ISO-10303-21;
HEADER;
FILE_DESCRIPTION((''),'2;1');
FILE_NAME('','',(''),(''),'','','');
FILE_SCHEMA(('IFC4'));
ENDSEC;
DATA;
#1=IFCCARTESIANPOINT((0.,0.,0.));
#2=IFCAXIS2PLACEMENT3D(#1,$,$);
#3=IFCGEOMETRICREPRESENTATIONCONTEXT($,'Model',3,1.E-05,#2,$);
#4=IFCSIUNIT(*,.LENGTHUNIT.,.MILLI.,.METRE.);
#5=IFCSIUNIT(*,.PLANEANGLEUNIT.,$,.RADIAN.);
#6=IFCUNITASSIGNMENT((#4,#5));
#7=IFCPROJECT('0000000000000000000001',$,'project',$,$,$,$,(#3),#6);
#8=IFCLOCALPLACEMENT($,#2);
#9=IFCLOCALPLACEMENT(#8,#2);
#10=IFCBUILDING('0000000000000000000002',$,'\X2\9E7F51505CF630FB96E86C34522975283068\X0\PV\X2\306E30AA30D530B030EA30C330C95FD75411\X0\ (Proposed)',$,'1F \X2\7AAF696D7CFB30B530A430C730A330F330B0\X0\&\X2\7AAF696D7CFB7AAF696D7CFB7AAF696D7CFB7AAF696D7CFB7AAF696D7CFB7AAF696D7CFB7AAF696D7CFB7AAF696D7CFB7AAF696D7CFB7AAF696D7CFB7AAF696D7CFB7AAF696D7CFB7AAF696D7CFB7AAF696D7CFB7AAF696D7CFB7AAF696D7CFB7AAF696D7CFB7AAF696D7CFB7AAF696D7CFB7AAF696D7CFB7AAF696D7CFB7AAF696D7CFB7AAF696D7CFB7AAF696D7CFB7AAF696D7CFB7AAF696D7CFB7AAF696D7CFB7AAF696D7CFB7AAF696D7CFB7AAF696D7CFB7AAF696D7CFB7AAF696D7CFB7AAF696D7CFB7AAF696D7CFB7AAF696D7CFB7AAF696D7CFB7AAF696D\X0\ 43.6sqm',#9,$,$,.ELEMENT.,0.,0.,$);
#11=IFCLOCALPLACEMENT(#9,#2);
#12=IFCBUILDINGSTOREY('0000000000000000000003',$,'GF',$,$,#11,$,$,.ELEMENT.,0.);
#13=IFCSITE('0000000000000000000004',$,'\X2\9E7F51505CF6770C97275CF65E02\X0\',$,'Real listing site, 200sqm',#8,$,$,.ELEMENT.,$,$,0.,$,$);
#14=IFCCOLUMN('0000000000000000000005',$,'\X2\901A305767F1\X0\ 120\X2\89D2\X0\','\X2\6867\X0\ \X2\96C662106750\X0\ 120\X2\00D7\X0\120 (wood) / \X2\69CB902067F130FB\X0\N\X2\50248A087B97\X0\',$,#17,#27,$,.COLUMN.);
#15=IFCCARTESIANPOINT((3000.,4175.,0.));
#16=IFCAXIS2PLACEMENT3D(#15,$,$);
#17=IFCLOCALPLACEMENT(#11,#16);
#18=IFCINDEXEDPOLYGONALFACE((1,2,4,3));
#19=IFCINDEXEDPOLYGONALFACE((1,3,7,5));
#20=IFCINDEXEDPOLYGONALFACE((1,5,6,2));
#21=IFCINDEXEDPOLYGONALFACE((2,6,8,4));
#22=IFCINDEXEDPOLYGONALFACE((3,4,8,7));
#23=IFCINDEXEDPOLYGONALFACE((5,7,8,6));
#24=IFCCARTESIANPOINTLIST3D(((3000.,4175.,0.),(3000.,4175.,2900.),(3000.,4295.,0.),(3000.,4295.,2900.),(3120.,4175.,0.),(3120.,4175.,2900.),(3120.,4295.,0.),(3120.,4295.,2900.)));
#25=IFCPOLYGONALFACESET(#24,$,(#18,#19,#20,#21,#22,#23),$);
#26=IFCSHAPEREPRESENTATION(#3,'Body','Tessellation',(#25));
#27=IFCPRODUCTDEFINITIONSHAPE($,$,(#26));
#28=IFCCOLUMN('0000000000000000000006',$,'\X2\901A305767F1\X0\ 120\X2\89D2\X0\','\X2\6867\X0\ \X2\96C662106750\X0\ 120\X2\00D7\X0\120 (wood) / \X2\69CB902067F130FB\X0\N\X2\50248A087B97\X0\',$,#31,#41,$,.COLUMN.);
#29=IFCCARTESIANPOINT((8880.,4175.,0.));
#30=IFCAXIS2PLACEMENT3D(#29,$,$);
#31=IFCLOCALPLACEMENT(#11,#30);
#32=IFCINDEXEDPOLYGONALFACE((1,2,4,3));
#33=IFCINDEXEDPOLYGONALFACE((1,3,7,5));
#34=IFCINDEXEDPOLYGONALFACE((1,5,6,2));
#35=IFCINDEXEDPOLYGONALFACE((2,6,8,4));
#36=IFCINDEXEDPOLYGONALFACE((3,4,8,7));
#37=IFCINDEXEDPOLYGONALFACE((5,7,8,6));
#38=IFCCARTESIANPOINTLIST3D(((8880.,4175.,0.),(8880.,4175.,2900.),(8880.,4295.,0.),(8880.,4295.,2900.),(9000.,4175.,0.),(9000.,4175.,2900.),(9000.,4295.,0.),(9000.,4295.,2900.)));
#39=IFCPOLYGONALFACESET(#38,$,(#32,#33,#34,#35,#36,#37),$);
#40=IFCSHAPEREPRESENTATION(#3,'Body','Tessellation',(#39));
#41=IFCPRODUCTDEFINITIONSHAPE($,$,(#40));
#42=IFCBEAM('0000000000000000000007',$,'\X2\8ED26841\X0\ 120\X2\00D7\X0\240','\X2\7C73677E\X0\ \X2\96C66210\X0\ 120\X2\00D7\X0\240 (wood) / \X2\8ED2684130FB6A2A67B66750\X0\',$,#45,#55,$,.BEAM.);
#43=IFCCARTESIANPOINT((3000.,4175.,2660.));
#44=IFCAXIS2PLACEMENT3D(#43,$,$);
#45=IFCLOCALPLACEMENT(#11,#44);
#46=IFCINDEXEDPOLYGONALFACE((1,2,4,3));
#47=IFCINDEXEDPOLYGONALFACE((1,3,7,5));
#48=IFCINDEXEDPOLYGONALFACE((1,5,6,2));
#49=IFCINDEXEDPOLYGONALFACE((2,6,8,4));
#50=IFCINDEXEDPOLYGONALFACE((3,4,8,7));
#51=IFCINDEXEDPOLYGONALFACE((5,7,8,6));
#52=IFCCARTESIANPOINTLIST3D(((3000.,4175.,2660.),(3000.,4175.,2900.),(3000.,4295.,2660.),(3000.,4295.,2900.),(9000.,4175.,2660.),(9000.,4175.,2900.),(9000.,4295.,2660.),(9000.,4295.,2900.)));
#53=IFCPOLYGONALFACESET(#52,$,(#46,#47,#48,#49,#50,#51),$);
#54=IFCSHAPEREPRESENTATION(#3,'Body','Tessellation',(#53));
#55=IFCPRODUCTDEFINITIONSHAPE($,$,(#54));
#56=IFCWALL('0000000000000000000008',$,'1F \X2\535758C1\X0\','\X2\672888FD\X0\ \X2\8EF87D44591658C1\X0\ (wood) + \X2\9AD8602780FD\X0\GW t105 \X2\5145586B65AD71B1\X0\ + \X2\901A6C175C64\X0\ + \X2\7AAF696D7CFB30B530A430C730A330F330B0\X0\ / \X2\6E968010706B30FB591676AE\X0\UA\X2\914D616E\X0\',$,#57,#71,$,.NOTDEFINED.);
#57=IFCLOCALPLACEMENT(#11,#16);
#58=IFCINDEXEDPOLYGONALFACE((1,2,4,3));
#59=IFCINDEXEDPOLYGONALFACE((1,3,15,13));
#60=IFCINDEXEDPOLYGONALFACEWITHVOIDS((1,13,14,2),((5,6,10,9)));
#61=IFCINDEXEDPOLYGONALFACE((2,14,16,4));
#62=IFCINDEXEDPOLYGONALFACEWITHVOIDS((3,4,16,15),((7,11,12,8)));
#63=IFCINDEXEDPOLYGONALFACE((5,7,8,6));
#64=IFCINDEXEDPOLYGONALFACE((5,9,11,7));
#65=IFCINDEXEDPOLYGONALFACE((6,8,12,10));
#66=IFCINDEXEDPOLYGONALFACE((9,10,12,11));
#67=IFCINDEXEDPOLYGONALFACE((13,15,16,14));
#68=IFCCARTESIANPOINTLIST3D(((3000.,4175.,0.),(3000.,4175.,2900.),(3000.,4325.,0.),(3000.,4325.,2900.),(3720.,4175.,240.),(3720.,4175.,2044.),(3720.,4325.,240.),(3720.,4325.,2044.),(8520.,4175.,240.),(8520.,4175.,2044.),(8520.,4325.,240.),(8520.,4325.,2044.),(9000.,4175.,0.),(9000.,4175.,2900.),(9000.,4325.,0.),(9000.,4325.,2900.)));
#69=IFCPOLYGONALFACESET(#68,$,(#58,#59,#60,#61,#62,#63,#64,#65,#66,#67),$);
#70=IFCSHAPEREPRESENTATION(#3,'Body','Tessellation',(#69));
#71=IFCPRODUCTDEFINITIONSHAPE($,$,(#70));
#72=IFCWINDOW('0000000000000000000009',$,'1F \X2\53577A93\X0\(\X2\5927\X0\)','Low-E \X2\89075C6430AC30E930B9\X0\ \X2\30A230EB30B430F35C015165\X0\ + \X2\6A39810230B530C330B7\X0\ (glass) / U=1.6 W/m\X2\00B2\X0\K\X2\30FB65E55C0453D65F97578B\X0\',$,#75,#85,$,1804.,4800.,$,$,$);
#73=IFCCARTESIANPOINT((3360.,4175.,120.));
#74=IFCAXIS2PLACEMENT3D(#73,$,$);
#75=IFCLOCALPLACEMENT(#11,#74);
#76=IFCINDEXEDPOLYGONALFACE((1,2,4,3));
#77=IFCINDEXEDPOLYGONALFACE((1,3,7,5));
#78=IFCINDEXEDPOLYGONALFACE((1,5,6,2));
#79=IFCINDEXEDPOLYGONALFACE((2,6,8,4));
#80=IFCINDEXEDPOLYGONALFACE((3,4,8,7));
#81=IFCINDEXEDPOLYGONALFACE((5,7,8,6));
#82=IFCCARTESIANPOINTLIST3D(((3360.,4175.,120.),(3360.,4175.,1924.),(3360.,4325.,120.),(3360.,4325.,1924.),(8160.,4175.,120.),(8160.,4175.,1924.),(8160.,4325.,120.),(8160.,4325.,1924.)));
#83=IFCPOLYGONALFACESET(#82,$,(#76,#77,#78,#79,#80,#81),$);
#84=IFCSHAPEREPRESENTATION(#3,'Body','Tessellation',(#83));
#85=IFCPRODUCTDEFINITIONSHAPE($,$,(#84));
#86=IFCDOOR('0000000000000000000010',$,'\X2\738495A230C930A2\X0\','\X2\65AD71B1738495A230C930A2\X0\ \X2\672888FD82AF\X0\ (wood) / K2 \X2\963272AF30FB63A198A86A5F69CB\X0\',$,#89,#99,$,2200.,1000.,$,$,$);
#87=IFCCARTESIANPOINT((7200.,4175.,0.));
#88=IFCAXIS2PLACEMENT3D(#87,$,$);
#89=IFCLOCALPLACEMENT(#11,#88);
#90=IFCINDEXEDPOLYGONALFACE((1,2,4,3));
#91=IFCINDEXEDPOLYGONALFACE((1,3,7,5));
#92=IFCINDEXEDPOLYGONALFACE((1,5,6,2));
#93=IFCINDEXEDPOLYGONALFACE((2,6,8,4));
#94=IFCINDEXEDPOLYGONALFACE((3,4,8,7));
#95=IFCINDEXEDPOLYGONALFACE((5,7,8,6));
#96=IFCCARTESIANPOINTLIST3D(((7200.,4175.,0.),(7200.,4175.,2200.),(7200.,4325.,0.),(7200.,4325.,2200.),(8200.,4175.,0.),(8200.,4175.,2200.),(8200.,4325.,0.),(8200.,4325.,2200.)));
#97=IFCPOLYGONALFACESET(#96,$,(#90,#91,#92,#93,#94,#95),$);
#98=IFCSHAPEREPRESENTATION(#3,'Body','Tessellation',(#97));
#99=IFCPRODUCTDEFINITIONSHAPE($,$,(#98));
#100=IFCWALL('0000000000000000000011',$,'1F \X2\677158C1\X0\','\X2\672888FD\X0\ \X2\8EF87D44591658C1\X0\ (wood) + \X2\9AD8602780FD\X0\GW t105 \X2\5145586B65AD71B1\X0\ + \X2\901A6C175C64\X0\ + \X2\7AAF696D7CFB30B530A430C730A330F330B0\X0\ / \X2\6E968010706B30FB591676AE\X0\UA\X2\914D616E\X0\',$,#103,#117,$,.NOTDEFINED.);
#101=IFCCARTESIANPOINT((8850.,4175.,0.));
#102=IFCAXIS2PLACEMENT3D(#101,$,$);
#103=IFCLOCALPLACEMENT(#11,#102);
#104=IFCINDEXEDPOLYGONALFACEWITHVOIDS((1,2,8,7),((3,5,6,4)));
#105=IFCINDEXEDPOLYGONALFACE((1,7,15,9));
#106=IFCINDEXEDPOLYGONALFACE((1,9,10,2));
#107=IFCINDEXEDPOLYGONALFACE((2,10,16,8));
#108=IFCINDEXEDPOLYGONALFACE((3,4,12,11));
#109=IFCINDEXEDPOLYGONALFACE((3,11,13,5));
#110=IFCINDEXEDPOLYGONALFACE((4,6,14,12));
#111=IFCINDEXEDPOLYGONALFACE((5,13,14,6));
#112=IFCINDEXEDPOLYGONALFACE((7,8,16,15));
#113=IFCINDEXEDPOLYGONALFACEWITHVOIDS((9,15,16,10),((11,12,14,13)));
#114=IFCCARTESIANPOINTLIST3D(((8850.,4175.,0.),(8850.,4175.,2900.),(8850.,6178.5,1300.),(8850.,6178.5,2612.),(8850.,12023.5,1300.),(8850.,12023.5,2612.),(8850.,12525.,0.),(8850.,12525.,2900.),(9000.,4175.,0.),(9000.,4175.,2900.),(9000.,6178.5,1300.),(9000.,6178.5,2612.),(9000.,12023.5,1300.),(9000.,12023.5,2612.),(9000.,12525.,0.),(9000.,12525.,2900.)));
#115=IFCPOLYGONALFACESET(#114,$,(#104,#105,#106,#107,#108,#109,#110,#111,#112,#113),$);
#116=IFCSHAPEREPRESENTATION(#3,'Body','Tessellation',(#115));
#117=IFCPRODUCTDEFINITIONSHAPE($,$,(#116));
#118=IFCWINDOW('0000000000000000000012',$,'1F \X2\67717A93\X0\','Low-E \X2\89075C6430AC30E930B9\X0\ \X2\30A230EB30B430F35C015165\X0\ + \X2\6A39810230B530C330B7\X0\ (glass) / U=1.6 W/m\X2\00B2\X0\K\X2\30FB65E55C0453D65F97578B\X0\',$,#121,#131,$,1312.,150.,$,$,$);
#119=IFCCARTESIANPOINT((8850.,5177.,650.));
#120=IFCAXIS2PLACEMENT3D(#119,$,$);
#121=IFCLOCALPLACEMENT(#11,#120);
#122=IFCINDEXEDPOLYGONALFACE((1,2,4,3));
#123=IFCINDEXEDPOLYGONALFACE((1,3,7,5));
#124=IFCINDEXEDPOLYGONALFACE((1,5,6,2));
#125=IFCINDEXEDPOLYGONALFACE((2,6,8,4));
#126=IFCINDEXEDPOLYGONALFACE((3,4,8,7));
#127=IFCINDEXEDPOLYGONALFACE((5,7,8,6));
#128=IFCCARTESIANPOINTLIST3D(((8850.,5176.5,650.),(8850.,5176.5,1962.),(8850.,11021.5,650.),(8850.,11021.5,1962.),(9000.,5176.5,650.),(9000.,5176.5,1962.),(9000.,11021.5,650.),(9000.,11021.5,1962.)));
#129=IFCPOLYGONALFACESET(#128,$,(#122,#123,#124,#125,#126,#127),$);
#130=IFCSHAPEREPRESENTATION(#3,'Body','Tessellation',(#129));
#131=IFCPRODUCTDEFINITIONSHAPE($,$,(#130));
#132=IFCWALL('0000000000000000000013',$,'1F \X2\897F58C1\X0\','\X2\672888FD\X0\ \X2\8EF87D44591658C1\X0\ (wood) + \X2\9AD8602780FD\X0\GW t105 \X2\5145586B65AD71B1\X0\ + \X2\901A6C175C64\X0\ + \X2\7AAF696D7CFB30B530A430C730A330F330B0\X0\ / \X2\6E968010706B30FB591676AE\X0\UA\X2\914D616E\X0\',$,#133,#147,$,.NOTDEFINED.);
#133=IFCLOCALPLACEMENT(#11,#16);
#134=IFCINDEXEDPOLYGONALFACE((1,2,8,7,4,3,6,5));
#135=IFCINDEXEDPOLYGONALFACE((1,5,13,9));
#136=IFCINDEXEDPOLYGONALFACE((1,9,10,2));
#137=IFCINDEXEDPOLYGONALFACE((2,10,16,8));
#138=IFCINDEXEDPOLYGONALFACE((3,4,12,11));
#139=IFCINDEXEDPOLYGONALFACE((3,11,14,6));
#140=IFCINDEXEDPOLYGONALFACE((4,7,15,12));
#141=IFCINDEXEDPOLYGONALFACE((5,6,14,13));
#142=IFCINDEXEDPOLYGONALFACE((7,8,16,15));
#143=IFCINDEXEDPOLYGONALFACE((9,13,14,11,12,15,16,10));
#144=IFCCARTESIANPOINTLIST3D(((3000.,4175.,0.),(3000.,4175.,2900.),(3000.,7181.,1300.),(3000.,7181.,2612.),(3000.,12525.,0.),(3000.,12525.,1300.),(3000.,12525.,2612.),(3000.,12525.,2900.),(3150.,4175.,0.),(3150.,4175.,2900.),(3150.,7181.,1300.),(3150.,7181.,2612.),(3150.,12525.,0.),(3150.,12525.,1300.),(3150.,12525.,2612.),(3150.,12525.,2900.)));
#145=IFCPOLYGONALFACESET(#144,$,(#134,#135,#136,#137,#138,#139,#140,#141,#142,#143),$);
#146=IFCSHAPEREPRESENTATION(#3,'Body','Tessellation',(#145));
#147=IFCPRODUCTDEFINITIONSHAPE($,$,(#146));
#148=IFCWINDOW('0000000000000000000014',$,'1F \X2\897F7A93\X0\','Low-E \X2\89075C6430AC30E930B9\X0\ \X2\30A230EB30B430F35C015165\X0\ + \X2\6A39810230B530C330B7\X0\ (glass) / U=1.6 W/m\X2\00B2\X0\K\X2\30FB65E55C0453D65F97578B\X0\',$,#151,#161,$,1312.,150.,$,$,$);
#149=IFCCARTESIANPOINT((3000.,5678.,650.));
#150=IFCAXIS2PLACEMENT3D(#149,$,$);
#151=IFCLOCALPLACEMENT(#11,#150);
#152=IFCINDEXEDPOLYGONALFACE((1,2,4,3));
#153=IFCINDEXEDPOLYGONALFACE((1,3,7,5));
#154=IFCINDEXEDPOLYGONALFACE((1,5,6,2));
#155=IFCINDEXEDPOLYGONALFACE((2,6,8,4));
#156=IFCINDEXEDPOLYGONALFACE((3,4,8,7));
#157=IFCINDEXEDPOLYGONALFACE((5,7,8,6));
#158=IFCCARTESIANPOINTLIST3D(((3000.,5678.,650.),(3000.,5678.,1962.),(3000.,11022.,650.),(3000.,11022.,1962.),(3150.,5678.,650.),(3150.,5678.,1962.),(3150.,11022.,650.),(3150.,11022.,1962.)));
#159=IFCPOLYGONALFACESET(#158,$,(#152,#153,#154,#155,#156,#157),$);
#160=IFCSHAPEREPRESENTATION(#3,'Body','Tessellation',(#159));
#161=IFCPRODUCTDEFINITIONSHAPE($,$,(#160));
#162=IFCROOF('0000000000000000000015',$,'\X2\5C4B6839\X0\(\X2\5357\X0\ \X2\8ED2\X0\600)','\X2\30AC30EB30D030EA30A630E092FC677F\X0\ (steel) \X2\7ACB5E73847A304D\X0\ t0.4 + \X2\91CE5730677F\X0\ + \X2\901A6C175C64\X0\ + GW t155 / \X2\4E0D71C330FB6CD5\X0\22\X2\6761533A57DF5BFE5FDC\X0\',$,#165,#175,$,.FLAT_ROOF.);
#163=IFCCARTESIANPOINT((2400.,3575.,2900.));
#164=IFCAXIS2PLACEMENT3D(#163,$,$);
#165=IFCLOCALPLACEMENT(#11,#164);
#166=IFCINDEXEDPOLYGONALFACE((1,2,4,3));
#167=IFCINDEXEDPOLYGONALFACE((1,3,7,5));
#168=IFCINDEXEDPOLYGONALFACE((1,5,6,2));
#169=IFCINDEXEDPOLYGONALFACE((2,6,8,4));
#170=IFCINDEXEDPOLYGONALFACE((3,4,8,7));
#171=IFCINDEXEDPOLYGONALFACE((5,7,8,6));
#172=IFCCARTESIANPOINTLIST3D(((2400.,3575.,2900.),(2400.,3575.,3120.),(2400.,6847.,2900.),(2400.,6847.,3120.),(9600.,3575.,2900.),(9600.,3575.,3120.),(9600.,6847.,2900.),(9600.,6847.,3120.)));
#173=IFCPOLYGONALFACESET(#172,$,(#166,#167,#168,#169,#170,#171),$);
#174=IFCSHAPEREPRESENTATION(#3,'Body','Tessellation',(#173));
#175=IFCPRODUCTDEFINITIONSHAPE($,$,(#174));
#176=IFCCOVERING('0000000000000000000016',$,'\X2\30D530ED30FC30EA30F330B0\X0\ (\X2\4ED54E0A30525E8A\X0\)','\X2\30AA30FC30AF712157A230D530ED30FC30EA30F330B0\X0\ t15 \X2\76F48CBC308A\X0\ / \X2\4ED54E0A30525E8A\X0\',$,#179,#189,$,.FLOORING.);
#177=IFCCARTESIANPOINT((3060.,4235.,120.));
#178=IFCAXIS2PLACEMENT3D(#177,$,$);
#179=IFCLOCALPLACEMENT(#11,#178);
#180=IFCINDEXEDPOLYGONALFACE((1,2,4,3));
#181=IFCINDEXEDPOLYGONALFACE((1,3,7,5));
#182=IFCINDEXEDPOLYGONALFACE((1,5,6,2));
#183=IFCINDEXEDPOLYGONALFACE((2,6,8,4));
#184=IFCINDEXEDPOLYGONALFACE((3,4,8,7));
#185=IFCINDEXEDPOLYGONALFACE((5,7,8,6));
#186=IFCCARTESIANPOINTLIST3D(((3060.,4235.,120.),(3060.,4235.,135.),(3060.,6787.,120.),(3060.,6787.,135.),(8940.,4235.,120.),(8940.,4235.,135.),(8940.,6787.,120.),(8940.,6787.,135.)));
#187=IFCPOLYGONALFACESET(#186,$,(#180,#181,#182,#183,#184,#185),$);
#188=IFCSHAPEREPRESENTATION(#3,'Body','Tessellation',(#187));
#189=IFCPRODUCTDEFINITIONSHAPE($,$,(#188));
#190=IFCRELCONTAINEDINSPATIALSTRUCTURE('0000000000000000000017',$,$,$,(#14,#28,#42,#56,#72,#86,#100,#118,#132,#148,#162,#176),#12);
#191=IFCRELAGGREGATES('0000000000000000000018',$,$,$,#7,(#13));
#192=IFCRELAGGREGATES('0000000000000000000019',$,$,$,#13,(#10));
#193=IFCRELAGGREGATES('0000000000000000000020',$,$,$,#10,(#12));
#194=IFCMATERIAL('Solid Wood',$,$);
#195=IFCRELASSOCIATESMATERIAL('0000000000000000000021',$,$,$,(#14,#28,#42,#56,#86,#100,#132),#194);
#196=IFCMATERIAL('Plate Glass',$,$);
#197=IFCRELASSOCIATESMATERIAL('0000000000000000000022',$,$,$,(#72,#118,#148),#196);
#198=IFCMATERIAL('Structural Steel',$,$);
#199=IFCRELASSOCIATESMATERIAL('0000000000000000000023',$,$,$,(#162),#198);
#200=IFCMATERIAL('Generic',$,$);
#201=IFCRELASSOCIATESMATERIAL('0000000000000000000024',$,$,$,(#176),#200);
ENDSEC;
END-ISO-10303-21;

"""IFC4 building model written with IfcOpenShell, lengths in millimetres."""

from ifc_helpers import new_model, si_unit, frame, frame_2d, origin, place, context, project, spatial, rectangle, extrude, material, element, fill, save


model = new_model("IFC4")

# Units and contexts
model_context = context("Model", 3, precision=1e-05, world=origin())
ifc_project = project(units=[si_unit("LENGTHUNIT", "METRE", prefix="MILLI"), si_unit("PLANEANGLEUNIT", "RADIAN")], contexts=[model_context])

# Site, building, storey
site_placement = place(None, origin())
site = spatial("IfcSite", under=ifc_project, at=site_placement, Name="鹿児島県霧島市", ObjectType="Real listing site, 200sqm", CompositionType="ELEMENT", RefElevation=0.0)
building_placement = place(site_placement, origin())
building = spatial("IfcBuilding", under=site, at=building_placement, Name="鹿児島・雨水利用とPVのオフグリッド志向 (Proposed)", ObjectType="1F 窯業系サイディング&窯業系窯業系窯業系窯業系窯業系窯業系窯業系窯業系窯業系窯業系窯業系窯業系窯業系窯業系窯業系窯業系窯業系窯業系窯業系窯業系窯業系窯業系窯業系窯業系窯業系窯業系窯業系窯業系窯業系窯業系窯業系窯業系窯業系窯業系窯業系窯業系窯業 43.6sqm", CompositionType="ELEMENT", ElevationOfRefHeight=0.0, ElevationOfTerrain=0.0)
storey_placement = place(building_placement, origin())
storey = spatial("IfcBuildingStorey", under=building, at=storey_placement, Name="GF", CompositionType="ELEMENT", Elevation=0.0)

# Columns
ifc_material_1 = material(Name="Solid Wood")
column_1_placement = place(storey_placement, frame((3000.0, 4175.0, 0.0)))
element("IfcColumn", 1, at=column_1_placement, inside=storey, material=ifc_material_1, Name="通し柱 120角", Description="桧 集成材 120×120 (wood) / 構造柱・N値計算", PredefinedType="COLUMN", context=model_context, shape_type="SweptSolid", body=[
    extrude(rectangle(XDim=120.0, YDim=120.0, at=frame_2d((60.0, 60.0))), frame((3000.0, 4175.0, 0.0)), (0.0, 0.0, 1.0), 2900.0),
])
column_2_placement = place(storey_placement, frame((8880.0, 4175.0, 0.0)))
element("IfcColumn", 2, at=column_2_placement, inside=storey, material=ifc_material_1, Name="通し柱 120角", Description="桧 集成材 120×120 (wood) / 構造柱・N値計算", PredefinedType="COLUMN", context=model_context, shape_type="SweptSolid", body=[
    extrude(rectangle(XDim=120.0, YDim=120.0, at=frame_2d((60.0, 60.0))), frame((8880.0, 4175.0, 0.0)), (0.0, 0.0, 1.0), 2900.0),
])

# Beam
beam_1_placement = place(storey_placement, frame((3000.0, 4175.0, 2660.0)))
element("IfcBeam", 3, at=beam_1_placement, inside=storey, material=ifc_material_1, Name="軒桁 120×240", Description="米松 集成 120×240 (wood) / 軒桁・横架材", PredefinedType="BEAM", context=model_context, shape_type="SweptSolid", body=[
    extrude(rectangle(XDim=6000.0, YDim=120.0, at=frame_2d((3000.0, 60.0))), frame((3000.0, 4175.0, 2660.0)), (0.0, 0.0, 1.0), 240.0),
])

# Wall, openings, window, door
wall_1_placement = place(storey_placement, frame((3000.0, 4175.0, 0.0)))
wall_1 = element("IfcWall", 4, at=wall_1_placement, inside=storey, material=ifc_material_1, Name="1F 南壁", Description="木製 軸組外壁 (wood) + 高性能GW t105 充填断熱 + 通気層 + 窯業系サイディング / 準耐火・外皮UA配慮", PredefinedType="NOTDEFINED", context=model_context, shape_type="SweptSolid", body=[
    extrude(rectangle(XDim=6000.0, YDim=150.0, at=frame_2d((3000.0, 75.0))), frame((3000.0, 4175.0, 0.0)), (0.0, 0.0, 1.0), 2900.0),
])
opening_1_placement = place(storey_placement, frame((3360.0, 4175.0, 120.0)))
opening_1 = element("IfcOpeningElement", 5, at=opening_1_placement, cuts=wall_1, PredefinedType="NOTDEFINED", context=model_context, shape_type="SweptSolid", body=[
    extrude(rectangle(XDim=4800.0, YDim=150.0, at=frame_2d((2400.0, 75.0))), frame((3360.0, 4175.0, 120.0)), (0.0, 0.0, 1.0), 1804.0),
])
opening_2_placement = place(storey_placement, frame((7200.0, 4175.0, 0.0)))
opening_2 = element("IfcOpeningElement", 6, at=opening_2_placement, cuts=wall_1, PredefinedType="NOTDEFINED", context=model_context, shape_type="SweptSolid", body=[
    extrude(rectangle(XDim=1000.0, YDim=150.0, at=frame_2d((500.0, 75.0))), frame((7200.0, 4175.0, 0.0)), (0.0, 0.0, 1.0), 2200.0),
])
ifc_material_2 = material(Name="Plate Glass")
window_1_placement = place(storey_placement, frame((3360.0, 4175.0, 120.0)))
window_1 = element("IfcWindow", 7, at=window_1_placement, inside=storey, material=ifc_material_2, Name="1F 南窓(大)", Description="Low-E 複層ガラス アルゴン封入 + 樹脂サッシ (glass) / U=1.6 W/m²K・日射取得型", OverallHeight=1804.0, OverallWidth=4800.0, context=model_context, shape_type="SweptSolid", body=[
    extrude(rectangle(XDim=4800.0, YDim=150.0, at=frame_2d((2400.0, 75.0))), frame((3360.0, 4175.0, 120.0)), (0.0, 0.0, 1.0), 1804.0),
])
fill(opening_1, window_1)
door_placement = place(storey_placement, frame((7200.0, 4175.0, 0.0)))
door = element("IfcDoor", 8, at=door_placement, inside=storey, material=ifc_material_1, Name="玄関ドア", Description="断熱玄関ドア 木製芯 (wood) / K2 防犯・採風機構", OverallHeight=2200.0, OverallWidth=1000.0, context=model_context, shape_type="SweptSolid", body=[
    extrude(rectangle(XDim=1000.0, YDim=150.0, at=frame_2d((500.0, 75.0))), frame((7200.0, 4175.0, 0.0)), (0.0, 0.0, 1.0), 2200.0),
])
fill(opening_2, door)

# Walls, openings, windows
wall_2_placement = place(storey_placement, frame((8850.0, 4175.0, 0.0)))
wall_2 = element("IfcWall", 9, at=wall_2_placement, inside=storey, material=ifc_material_1, Name="1F 東壁", Description="木製 軸組外壁 (wood) + 高性能GW t105 充填断熱 + 通気層 + 窯業系サイディング / 準耐火・外皮UA配慮", PredefinedType="NOTDEFINED", context=model_context, shape_type="SweptSolid", body=[
    extrude(rectangle(XDim=150.0, YDim=8350.0, at=frame_2d((75.0, 4175.0))), frame((8850.0, 4175.0, 0.0)), (0.0, 0.0, 1.0), 2900.0),
])
opening_3_placement = place(storey_placement, frame((8850.0, 5177.0, 650.0)))
opening_3 = element("IfcOpeningElement", 10, at=opening_3_placement, cuts=wall_2, PredefinedType="NOTDEFINED", context=model_context, shape_type="SweptSolid", body=[
    extrude(rectangle(XDim=150.0, YDim=5845.0, at=frame_2d((75.0, 2922.0))), frame((8850.0, 5177.0, 650.0)), (0.0, 0.0, 1.0), 1312.0),
])
window_2_placement = place(storey_placement, frame((8850.0, 5177.0, 650.0)))
window_2 = element("IfcWindow", 11, at=window_2_placement, inside=storey, material=ifc_material_2, Name="1F 東窓", Description="Low-E 複層ガラス アルゴン封入 + 樹脂サッシ (glass) / U=1.6 W/m²K・日射取得型", OverallHeight=1312.0, OverallWidth=150.0, context=model_context, shape_type="SweptSolid", body=[
    extrude(rectangle(XDim=150.0, YDim=5845.0, at=frame_2d((75.0, 2922.0))), frame((8850.0, 5177.0, 650.0)), (0.0, 0.0, 1.0), 1312.0),
])
fill(opening_3, window_2)
wall_3_placement = place(storey_placement, frame((3000.0, 4175.0, 0.0)))
wall_3 = element("IfcWall", 12, at=wall_3_placement, inside=storey, material=ifc_material_1, Name="1F 西壁", Description="木製 軸組外壁 (wood) + 高性能GW t105 充填断熱 + 通気層 + 窯業系サイディング / 準耐火・外皮UA配慮", PredefinedType="NOTDEFINED", context=model_context, shape_type="SweptSolid", body=[
    extrude(rectangle(XDim=150.0, YDim=8350.0, at=frame_2d((75.0, 4175.0))), frame((3000.0, 4175.0, 0.0)), (0.0, 0.0, 1.0), 2900.0),
])
opening_4_placement = place(storey_placement, frame((3000.0, 5678.0, 650.0)))
opening_4 = element("IfcOpeningElement", 13, at=opening_4_placement, cuts=wall_3, PredefinedType="NOTDEFINED", context=model_context, shape_type="SweptSolid", body=[
    extrude(rectangle(XDim=150.0, YDim=5344.0, at=frame_2d((75.0, 2672.0))), frame((3000.0, 5678.0, 650.0)), (0.0, 0.0, 1.0), 1312.0),
])
window_3_placement = place(storey_placement, frame((3000.0, 5678.0, 650.0)))
window_3 = element("IfcWindow", 14, at=window_3_placement, inside=storey, material=ifc_material_2, Name="1F 西窓", Description="Low-E 複層ガラス アルゴン封入 + 樹脂サッシ (glass) / U=1.6 W/m²K・日射取得型", OverallHeight=1312.0, OverallWidth=150.0, context=model_context, shape_type="SweptSolid", body=[
    extrude(rectangle(XDim=150.0, YDim=5344.0, at=frame_2d((75.0, 2672.0))), frame((3000.0, 5678.0, 650.0)), (0.0, 0.0, 1.0), 1312.0),
])
fill(opening_4, window_3)

# Roof
ifc_material_3 = material(Name="Structural Steel")
roof_placement = place(storey_placement, frame((2400.0, 3575.0, 2900.0)))
element("IfcRoof", 15, at=roof_placement, inside=storey, material=ifc_material_3, Name="屋根(南 軒600)", Description="ガルバリウム鋼板 (steel) 立平葺き t0.4 + 野地板 + 通気層 + GW t155 / 不燃・法22条区域対応", PredefinedType="FLAT_ROOF", context=model_context, shape_type="SweptSolid", body=[
    extrude(rectangle(XDim=7200.0, YDim=3272.0, at=frame_2d((3600.0, 1636.0))), frame((2400.0, 3575.0, 2900.0)), (0.0, 0.0, 1.0), 220.0),
])

# Covering
ifc_material_4 = material(Name="Generic")
covering_1_placement = place(storey_placement, frame((3060.0, 4235.0, 120.0)))
element("IfcCovering", 16, at=covering_1_placement, inside=storey, material=ifc_material_4, Name="フローリング (仕上げ床)", Description="オーク無垢フローリング t15 直貼り / 仕上げ床", PredefinedType="FLOORING", context=model_context, shape_type="SweptSolid", body=[
    extrude(rectangle(XDim=5880.0, YDim=2552.0, at=frame_2d((2940.0, 1276.0))), frame((3060.0, 4235.0, 120.0)), (0.0, 0.0, 1.0), 15.0),
])

save(model, "model.ifc")
